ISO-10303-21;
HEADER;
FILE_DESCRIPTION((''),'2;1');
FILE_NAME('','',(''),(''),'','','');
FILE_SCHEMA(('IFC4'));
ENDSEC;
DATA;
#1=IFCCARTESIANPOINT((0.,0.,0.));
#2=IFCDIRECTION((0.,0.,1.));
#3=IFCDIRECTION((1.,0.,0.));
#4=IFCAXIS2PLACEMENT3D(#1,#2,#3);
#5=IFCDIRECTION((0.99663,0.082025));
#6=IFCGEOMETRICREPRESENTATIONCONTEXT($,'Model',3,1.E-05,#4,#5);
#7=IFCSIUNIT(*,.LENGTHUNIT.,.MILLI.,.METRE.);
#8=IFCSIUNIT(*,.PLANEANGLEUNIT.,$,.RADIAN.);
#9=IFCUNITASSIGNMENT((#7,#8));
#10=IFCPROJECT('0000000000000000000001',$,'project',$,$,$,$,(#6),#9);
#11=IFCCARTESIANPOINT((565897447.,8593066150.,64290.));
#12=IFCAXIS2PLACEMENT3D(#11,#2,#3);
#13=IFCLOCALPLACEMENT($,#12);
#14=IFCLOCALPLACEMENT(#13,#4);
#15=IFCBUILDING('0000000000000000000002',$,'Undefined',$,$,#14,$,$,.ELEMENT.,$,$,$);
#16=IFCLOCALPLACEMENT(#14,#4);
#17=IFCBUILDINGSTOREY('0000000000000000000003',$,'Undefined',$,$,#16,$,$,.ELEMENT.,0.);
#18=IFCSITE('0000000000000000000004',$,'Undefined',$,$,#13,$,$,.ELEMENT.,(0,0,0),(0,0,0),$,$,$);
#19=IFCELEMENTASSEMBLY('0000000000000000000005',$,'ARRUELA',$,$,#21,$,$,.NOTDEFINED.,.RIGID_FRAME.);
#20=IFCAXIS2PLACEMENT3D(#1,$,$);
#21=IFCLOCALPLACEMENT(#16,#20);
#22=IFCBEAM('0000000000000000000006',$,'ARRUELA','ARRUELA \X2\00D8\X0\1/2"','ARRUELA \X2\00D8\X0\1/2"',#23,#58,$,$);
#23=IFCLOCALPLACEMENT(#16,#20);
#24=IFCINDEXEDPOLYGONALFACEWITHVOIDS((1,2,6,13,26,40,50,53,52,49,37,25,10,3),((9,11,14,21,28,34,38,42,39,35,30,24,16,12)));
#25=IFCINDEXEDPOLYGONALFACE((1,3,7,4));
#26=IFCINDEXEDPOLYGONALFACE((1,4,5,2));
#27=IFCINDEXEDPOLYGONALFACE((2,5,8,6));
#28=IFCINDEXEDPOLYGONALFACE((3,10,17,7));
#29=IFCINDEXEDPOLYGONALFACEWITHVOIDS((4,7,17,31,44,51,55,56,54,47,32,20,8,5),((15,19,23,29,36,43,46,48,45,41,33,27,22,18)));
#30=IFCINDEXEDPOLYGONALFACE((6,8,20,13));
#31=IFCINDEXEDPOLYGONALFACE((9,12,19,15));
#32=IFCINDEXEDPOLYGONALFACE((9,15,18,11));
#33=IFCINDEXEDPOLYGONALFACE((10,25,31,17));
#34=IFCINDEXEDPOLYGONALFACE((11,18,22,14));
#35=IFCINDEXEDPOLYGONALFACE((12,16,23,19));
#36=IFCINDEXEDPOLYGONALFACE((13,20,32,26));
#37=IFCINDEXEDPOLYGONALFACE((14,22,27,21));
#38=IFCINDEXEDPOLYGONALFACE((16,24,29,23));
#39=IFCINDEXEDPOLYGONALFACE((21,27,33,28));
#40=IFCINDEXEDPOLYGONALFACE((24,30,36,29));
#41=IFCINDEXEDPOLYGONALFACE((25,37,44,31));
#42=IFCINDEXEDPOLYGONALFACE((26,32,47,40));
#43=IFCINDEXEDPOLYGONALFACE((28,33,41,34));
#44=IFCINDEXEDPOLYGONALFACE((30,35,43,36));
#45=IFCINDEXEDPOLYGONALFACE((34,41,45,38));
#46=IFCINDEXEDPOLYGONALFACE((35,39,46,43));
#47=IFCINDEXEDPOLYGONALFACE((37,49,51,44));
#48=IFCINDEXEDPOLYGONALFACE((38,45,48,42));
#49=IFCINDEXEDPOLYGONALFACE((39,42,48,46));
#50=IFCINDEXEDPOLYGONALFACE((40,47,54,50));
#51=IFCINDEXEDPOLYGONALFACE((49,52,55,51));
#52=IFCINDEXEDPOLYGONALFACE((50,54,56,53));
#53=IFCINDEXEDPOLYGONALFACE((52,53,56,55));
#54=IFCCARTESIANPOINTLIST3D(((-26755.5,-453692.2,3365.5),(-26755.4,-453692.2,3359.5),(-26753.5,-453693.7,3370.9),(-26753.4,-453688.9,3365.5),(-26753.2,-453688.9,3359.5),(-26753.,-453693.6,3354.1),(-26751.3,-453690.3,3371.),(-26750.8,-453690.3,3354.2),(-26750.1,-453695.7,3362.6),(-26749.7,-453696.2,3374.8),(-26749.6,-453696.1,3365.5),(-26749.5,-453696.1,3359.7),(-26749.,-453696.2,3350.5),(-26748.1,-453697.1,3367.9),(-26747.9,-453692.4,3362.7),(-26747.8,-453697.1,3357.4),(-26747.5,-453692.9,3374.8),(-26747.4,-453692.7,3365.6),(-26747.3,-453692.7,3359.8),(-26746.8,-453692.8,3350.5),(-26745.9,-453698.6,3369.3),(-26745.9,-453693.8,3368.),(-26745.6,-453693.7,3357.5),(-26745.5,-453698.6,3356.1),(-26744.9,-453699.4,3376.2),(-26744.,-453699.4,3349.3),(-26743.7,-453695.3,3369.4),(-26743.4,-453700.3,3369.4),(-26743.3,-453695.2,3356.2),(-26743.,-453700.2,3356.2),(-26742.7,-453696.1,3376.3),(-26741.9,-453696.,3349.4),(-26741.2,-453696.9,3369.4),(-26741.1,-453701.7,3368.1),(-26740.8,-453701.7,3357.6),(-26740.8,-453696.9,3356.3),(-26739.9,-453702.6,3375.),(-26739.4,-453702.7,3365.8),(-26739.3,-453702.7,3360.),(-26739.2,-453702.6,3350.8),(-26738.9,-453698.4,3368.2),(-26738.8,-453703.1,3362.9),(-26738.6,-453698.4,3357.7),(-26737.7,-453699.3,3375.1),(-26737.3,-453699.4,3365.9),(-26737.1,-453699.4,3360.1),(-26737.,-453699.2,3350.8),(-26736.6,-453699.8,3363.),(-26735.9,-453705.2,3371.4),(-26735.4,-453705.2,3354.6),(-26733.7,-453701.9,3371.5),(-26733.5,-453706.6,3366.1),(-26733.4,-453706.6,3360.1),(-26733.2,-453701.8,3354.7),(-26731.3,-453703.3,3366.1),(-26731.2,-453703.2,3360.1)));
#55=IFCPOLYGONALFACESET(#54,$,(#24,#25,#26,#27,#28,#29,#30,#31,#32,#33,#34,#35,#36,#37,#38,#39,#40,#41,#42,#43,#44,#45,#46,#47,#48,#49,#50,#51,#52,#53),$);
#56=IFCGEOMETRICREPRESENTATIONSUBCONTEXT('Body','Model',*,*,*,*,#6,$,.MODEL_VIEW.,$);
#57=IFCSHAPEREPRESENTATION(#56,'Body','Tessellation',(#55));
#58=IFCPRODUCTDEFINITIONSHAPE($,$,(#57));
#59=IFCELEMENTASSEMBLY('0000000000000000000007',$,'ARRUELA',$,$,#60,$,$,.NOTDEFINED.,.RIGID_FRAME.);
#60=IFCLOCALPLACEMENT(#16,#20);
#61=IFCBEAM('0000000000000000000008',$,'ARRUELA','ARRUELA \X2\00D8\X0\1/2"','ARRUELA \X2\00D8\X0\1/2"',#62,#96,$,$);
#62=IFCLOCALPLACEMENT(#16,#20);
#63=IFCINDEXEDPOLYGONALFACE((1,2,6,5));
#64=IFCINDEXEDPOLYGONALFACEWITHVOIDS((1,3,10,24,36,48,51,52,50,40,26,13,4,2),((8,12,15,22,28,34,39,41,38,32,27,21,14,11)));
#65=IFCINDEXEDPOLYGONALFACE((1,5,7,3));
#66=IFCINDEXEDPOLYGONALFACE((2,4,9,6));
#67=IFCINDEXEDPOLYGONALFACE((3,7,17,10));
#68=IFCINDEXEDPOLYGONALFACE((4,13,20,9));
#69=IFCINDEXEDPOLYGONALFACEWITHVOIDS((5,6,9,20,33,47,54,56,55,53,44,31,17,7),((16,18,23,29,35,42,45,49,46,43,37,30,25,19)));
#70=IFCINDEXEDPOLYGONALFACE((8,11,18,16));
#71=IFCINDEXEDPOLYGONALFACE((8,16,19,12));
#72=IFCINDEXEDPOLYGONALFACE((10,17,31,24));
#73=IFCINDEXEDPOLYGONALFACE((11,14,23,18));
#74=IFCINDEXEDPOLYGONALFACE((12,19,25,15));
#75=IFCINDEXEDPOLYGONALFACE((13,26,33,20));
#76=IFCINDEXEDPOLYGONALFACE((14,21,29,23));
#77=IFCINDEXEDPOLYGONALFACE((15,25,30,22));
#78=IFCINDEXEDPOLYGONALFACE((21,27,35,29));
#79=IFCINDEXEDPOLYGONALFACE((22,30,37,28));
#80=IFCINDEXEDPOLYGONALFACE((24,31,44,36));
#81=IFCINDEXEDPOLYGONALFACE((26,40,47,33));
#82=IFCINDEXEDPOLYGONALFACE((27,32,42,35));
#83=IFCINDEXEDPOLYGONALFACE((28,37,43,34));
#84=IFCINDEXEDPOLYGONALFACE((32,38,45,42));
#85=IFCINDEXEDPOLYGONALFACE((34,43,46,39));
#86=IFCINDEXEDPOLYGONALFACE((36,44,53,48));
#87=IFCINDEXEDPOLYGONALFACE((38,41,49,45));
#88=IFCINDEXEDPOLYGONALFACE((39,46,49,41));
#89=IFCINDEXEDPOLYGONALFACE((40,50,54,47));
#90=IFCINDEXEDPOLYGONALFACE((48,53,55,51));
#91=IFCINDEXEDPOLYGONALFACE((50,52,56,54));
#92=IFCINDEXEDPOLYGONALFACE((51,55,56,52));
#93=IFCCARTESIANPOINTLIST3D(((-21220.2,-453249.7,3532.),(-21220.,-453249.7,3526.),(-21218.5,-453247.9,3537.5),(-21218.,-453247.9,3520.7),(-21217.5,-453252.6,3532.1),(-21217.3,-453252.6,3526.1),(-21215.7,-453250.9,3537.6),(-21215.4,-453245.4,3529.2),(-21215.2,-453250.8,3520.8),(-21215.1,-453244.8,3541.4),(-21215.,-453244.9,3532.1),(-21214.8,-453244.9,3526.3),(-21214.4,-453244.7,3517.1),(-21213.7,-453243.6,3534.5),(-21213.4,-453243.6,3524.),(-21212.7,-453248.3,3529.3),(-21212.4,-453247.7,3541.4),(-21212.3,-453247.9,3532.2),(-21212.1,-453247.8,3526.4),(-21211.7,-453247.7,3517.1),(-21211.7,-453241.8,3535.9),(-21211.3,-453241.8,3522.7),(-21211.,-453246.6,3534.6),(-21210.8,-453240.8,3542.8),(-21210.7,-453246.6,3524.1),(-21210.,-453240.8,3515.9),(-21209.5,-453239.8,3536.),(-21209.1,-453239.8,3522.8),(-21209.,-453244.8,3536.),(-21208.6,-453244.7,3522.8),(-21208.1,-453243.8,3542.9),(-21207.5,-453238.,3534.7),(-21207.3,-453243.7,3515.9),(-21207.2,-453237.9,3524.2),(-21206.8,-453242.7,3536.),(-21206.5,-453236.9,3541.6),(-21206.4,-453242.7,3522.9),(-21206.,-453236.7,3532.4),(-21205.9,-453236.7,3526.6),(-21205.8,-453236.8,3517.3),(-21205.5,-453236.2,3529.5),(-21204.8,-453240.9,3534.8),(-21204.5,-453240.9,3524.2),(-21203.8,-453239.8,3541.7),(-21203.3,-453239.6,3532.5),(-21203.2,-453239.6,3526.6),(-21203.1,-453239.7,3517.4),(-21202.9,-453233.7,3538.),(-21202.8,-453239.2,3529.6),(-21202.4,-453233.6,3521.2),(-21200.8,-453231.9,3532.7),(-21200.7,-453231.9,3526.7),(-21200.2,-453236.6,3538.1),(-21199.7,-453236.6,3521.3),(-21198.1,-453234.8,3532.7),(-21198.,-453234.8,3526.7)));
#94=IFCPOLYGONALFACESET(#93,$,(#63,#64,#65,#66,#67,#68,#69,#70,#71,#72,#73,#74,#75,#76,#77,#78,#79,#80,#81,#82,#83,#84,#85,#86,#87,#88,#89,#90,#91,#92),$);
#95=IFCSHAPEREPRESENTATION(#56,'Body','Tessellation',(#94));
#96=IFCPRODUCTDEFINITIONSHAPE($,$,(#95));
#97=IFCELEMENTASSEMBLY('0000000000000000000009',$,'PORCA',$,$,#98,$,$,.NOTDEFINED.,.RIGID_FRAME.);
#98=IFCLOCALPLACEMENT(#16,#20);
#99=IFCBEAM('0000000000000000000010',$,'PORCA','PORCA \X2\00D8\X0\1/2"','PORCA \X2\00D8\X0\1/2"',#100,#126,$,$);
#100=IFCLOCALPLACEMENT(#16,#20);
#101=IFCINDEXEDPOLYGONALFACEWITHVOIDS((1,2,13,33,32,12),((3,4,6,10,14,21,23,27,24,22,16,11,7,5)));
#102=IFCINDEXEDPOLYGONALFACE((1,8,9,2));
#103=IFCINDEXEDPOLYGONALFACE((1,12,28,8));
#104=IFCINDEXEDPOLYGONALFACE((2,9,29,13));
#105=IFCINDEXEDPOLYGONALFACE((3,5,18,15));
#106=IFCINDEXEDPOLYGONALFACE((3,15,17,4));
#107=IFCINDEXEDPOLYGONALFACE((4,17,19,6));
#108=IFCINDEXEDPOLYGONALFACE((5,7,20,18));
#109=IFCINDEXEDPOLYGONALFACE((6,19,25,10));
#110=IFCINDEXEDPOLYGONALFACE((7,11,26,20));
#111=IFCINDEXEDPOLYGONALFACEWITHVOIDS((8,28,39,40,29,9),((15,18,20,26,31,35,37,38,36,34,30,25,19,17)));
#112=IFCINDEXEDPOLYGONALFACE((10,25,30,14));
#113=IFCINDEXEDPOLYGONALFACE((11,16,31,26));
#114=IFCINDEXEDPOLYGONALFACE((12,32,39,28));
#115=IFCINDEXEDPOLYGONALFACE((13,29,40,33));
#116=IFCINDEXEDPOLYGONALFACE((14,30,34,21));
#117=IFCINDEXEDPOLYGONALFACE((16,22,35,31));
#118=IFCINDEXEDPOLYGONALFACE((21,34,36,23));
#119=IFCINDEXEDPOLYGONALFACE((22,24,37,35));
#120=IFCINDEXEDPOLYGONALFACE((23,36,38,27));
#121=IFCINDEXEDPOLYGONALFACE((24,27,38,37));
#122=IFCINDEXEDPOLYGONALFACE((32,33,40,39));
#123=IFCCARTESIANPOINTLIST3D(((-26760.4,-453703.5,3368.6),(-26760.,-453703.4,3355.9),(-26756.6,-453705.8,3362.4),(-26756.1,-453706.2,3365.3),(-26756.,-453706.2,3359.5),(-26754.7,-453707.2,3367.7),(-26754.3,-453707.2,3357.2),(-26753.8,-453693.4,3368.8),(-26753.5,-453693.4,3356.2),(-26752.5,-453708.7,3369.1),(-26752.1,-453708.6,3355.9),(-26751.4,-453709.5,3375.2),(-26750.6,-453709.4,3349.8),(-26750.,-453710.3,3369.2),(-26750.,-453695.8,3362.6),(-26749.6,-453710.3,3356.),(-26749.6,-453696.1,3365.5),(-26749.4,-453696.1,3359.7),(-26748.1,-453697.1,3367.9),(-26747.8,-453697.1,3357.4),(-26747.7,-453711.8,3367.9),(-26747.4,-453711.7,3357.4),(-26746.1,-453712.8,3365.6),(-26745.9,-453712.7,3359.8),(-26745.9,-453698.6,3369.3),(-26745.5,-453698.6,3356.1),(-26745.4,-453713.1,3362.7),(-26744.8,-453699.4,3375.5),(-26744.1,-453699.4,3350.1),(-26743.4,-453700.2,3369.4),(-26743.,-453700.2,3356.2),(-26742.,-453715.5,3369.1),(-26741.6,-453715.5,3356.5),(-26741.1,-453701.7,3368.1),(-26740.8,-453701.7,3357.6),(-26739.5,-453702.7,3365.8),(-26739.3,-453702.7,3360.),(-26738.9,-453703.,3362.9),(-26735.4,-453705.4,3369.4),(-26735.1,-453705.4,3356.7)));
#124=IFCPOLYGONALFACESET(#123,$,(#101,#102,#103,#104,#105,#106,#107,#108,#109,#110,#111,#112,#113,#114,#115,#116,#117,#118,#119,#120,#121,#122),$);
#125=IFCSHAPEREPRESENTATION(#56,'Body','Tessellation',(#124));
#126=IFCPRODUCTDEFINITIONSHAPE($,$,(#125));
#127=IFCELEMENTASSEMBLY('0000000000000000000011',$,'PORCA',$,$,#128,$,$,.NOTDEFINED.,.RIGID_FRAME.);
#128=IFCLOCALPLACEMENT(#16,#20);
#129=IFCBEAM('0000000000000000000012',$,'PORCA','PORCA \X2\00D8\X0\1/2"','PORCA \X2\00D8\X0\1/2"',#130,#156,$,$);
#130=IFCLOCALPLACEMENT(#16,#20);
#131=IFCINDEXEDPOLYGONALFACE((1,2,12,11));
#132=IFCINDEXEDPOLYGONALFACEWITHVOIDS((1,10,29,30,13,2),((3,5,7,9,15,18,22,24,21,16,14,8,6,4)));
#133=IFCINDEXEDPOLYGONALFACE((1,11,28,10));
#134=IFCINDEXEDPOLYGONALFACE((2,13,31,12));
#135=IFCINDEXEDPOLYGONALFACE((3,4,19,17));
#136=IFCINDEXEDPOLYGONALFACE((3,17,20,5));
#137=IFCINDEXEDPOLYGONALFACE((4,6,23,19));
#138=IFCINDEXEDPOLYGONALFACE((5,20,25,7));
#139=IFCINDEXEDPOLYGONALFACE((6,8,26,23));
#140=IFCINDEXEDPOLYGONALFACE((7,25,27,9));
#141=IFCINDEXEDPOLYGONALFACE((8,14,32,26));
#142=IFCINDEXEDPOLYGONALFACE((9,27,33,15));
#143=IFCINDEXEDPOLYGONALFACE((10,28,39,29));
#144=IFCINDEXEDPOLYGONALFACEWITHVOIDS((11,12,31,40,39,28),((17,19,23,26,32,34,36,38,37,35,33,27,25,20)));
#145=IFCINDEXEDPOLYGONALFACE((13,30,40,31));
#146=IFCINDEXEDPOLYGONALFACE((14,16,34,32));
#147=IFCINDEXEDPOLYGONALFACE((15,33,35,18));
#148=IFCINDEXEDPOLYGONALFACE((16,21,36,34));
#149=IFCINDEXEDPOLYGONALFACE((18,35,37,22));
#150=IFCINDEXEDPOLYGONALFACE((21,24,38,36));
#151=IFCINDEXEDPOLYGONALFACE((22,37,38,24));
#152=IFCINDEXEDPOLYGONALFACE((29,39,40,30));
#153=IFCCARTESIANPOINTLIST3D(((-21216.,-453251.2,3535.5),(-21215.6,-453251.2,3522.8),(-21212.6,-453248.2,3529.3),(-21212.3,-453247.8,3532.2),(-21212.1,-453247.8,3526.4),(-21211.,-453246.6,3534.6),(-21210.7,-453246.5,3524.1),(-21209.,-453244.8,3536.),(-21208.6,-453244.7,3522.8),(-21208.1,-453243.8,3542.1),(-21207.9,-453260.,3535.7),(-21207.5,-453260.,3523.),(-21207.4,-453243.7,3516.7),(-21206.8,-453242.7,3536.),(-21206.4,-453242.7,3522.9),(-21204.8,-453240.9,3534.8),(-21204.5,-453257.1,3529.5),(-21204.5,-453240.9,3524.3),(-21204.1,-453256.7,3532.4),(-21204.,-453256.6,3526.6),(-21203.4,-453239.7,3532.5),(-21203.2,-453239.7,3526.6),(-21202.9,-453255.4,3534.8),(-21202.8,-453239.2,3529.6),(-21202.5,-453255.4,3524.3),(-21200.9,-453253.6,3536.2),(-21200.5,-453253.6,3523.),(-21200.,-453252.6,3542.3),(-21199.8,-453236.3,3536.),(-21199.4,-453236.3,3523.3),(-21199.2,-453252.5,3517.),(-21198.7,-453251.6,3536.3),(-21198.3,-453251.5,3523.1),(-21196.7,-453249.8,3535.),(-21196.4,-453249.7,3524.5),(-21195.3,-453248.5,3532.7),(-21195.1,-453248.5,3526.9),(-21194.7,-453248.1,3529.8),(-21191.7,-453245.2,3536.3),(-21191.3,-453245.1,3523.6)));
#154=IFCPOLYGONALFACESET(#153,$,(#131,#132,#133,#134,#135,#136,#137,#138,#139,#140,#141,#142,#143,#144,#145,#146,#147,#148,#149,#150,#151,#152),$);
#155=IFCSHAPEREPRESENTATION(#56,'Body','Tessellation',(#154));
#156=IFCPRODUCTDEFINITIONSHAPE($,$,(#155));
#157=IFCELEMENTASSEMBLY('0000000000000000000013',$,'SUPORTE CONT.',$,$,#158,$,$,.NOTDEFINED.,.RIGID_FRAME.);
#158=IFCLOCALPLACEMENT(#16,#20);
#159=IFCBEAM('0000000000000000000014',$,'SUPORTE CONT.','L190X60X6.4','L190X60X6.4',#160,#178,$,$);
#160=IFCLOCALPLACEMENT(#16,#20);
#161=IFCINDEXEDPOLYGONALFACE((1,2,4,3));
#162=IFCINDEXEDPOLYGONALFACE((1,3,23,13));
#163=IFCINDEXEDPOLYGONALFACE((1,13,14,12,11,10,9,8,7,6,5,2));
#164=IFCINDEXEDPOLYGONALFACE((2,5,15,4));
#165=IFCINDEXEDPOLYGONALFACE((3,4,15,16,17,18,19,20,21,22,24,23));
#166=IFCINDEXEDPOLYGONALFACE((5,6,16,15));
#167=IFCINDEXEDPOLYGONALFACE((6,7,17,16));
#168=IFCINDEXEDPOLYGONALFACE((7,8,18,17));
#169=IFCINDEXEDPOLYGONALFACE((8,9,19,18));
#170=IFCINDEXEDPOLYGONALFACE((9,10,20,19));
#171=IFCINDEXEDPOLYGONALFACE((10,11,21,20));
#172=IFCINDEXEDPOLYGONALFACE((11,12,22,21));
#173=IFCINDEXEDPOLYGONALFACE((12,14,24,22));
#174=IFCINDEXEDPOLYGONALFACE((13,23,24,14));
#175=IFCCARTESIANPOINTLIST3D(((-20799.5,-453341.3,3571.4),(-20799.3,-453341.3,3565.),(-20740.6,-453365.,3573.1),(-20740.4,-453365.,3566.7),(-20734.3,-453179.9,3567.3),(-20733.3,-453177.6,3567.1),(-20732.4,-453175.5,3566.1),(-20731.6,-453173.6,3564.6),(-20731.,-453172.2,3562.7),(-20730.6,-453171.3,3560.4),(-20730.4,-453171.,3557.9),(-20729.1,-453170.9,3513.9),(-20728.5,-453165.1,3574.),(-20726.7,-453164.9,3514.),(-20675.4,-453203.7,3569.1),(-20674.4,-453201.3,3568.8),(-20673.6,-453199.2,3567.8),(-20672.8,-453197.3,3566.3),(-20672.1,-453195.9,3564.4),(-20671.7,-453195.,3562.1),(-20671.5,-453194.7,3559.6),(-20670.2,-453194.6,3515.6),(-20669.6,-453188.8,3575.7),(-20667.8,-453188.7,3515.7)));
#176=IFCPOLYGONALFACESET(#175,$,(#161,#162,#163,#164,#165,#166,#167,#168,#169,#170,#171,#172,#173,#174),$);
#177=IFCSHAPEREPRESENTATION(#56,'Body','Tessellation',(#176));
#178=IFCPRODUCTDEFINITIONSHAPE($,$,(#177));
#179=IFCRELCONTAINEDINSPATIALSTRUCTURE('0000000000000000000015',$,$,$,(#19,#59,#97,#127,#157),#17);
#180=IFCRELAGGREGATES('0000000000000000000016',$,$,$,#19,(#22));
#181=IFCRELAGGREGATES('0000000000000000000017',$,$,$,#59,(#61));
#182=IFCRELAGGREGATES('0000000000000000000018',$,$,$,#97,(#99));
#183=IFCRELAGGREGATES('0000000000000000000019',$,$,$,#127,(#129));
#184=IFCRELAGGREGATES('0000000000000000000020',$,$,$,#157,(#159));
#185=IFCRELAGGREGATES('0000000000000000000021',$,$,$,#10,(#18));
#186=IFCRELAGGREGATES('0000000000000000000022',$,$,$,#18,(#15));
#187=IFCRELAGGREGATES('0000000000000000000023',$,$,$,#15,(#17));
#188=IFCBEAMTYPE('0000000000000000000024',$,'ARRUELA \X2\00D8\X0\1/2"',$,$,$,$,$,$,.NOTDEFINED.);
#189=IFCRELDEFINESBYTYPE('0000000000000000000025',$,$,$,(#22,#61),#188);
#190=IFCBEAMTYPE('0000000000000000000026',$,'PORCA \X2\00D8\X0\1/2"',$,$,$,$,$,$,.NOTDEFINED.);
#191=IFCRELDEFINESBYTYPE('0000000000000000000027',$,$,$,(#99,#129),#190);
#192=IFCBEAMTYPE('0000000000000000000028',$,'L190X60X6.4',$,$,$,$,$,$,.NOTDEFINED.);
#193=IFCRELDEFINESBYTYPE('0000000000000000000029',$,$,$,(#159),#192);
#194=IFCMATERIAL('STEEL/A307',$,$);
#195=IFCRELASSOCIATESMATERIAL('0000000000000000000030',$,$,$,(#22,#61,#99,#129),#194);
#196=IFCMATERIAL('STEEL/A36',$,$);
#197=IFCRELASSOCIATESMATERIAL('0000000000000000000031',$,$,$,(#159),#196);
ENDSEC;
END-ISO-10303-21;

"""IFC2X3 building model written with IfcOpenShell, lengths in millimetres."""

from ifc_helpers import new_model, si_unit, direction, frame, origin_with_axes, origin_2d_with_axis, place, context, subcontext, project, spatial, polyline, l_section, outline, extrude, material, type_object, element, aggregate, save


model = new_model("IFC2X3")

# Units and contexts
model_context = context("Model", 3, precision=1e-05, world=origin_with_axes(), true_north=direction((0.99663, 0.082025)))
body_context = subcontext(model_context, "Body", "Model", "MODEL_VIEW")
ifc_project = project(units=[si_unit("LENGTHUNIT", "METRE", prefix="MILLI"), si_unit("PLANEANGLEUNIT", "RADIAN")], contexts=[model_context])

# Site, building, storey
site_placement = place(None, frame((565897447.0, 8593066150.0, 64290.0), z_axis=(0.0, 0.0, 1.0), x_axis=(1.0, 0.0, 0.0)))
site = spatial("IfcSite", under=ifc_project, at=site_placement, Name="Undefined", CompositionType="ELEMENT", RefLatitude=(0, 0, 0), RefLongitude=(0, 0, 0))
building_placement = place(site_placement, origin_with_axes())
building = spatial("IfcBuilding", under=site, at=building_placement, Name="Undefined", CompositionType="ELEMENT")
storey_placement = place(building_placement, origin_with_axes())
storey = spatial("IfcBuildingStorey", under=building, at=storey_placement, Name="Undefined", CompositionType="ELEMENT", Elevation=0.0)

# Element assemblies, beams
assembly_1_placement = place(storey_placement, origin_with_axes())
assembly_1 = element("IfcElementAssembly", 1, at=assembly_1_placement, inside=storey, Name="ARRUELA", AssemblyPlace="NOTDEFINED", PredefinedType="RIGID_FRAME")
ifc_material_1 = material(Name="STEEL/A307")
beam_type_1 = type_object("IfcBeamType", Name="ARRUELA Ø1/2\"", PredefinedType="NOTDEFINED")
beam_1_placement = place(assembly_1_placement, frame((-26744.4, -453699.4, 3362.8), z_axis=(0.836984, -0.546715, 0.02368), x_axis=(0.546411, 0.837315, 0.018398)))
beam_1 = element("IfcBeam", 2, at=beam_1_placement, type_object=beam_type_1, material=ifc_material_1, Name="ARRUELA", Description="ARRUELA Ø1/2\"", ObjectType="ARRUELA Ø1/2\"", context=body_context, shape_type="SweptSolid", body=[
    extrude(outline(polyline([(-12.2, 5.9), (-8.4, 10.5), (-3.0, 13.2), (3.0, 13.2), (8.4, 10.5), (12.2, 5.9), (13.5, 0.0), (12.2, -5.9), (8.4, -10.5), (3.0, -13.2), (-3.0, -13.2), (-8.4, -10.5), (-12.2, -5.9), (-13.5, 0.0), (-12.2, 5.9)]), holes=[polyline([(5.3, 4.2), (2.9, 6.1), (0.0, 6.8), (-2.9, 6.1), (-5.3, 4.2), (-6.6, 1.5), (-6.6, -1.5), (-5.3, -4.2), (-2.9, -6.1), (0.0, -6.7), (2.9, -6.1), (5.3, -4.2), (6.6, -1.5), (6.6, 1.5), (5.3, 4.2)])]), frame((4.0, 0.0, 0.0), z_axis=(-1.0, 0.0, 0.0), x_axis=(0.0, -1.0, 0.0)), (0.0, 0.0, 1.0), 4.0),
])
aggregate(assembly_1, [beam_1])
assembly_2_placement = place(storey_placement, origin_with_axes())
assembly_2 = element("IfcElementAssembly", 3, at=assembly_2_placement, inside=storey, Name="ARRUELA", AssemblyPlace="NOTDEFINED", PredefinedType="RIGID_FRAME")
beam_2_placement = place(assembly_2_placement, frame((-21207.7, -453243.7, 3529.4), z_axis=(0.736334, 0.676203, 0.02368), x_axis=(-0.675958, 0.736711, -0.018398)))
beam_2 = element("IfcBeam", 4, at=beam_2_placement, type_object=beam_type_1, material=ifc_material_1, Name="ARRUELA", Description="ARRUELA Ø1/2\"", ObjectType="ARRUELA Ø1/2\"", context=body_context, shape_type="SweptSolid", body=[
    extrude(outline(polyline([(-12.2, 5.9), (-8.4, 10.5), (-3.0, 13.2), (3.0, 13.2), (8.4, 10.5), (12.2, 5.9), (13.5, 0.0), (12.2, -5.9), (8.4, -10.5), (3.0, -13.2), (-3.0, -13.2), (-8.4, -10.5), (-12.2, -5.9), (-13.5, 0.0), (-12.2, 5.9)]), holes=[polyline([(5.3, 4.2), (2.9, 6.1), (0.0, 6.8), (-2.9, 6.1), (-5.3, 4.2), (-6.6, 1.5), (-6.6, -1.5), (-5.3, -4.2), (-2.9, -6.1), (0.0, -6.7), (2.9, -6.1), (5.3, -4.2), (6.6, -1.5), (6.6, 1.5), (5.3, 4.2)])]), frame((4.0, 0.0, 0.0), z_axis=(-1.0, 0.0, 0.0), x_axis=(0.0, -1.0, 0.0)), (0.0, 0.0, 1.0), 4.0),
])
aggregate(assembly_2, [beam_2])
assembly_3_placement = place(storey_placement, origin_with_axes())
assembly_3 = element("IfcElementAssembly", 5, at=assembly_3_placement, inside=storey, Name="PORCA", AssemblyPlace="NOTDEFINED", PredefinedType="RIGID_FRAME")
beam_type_2 = type_object("IfcBeamType", Name="PORCA Ø1/2\"", PredefinedType="NOTDEFINED")
beam_3_placement = place(assembly_3_placement, frame((-26751.0, -453709.5, 3362.5), z_axis=(0.836984, -0.546715, 0.02368), x_axis=(0.546411, 0.837315, 0.018398)))
beam_3 = element("IfcBeam", 6, at=beam_3_placement, type_object=beam_type_2, material=ifc_material_1, Name="PORCA", Description="PORCA Ø1/2\"", ObjectType="PORCA Ø1/2\"", context=body_context, shape_type="SweptSolid", body=[
    extrude(outline(polyline([(-6.3, -11.0), (-12.7, 0.0), (-6.3, 11.0), (6.3, 11.0), (12.7, 0.0), (6.3, -11.0), (-6.3, -11.0)]), holes=[polyline([(5.3, 4.2), (2.9, 6.0), (0.0, 6.7), (-2.9, 6.0), (-5.3, 4.2), (-6.6, 1.5), (-6.6, -1.5), (-5.3, -4.2), (-2.9, -6.0), (0.0, -6.7), (2.9, -6.0), (5.3, -4.2), (6.6, -1.5), (6.6, 1.5), (5.3, 4.2)])]), frame((12.0, 0.0, 0.0), z_axis=(-1.0, 0.0, 0.0), x_axis=(0.0, -1.0, 0.0)), (0.0, 0.0, 1.0), 12.0),
])
aggregate(assembly_3, [beam_3])
assembly_4_placement = place(storey_placement, origin_with_axes())
assembly_4 = element("IfcElementAssembly", 7, at=assembly_4_placement, inside=storey, Name="PORCA", AssemblyPlace="NOTDEFINED", PredefinedType="RIGID_FRAME")
beam_4_placement = place(assembly_4_placement, frame((-21199.6, -453252.6, 3529.6), z_axis=(0.736334, 0.676203, 0.02368), x_axis=(-0.675958, 0.736711, -0.018398)))
beam_4 = element("IfcBeam", 8, at=beam_4_placement, type_object=beam_type_2, material=ifc_material_1, Name="PORCA", Description="PORCA Ø1/2\"", ObjectType="PORCA Ø1/2\"", context=body_context, shape_type="SweptSolid", body=[
    extrude(outline(polyline([(-6.3, -11.0), (-12.7, 0.0), (-6.3, 11.0), (6.3, 11.0), (12.7, 0.0), (6.3, -11.0), (-6.3, -11.0)]), holes=[polyline([(5.3, 4.2), (2.9, 6.0), (0.0, 6.7), (-2.9, 6.0), (-5.3, 4.2), (-6.6, 1.5), (-6.6, -1.5), (-5.3, -4.2), (-2.9, -6.0), (0.0, -6.7), (2.9, -6.0), (5.3, -4.2), (6.6, -1.5), (6.6, 1.5), (5.3, 4.2)])]), frame((12.0, 0.0, 0.0), z_axis=(-1.0, 0.0, 0.0), x_axis=(0.0, -1.0, 0.0)), (0.0, 0.0, 1.0), 12.0),
])
aggregate(assembly_4, [beam_4])
assembly_5_placement = place(storey_placement, origin_with_axes())
assembly_5 = element("IfcElementAssembly", 9, at=assembly_5_placement, inside=storey, Name="SUPORTE CONT.", AssemblyPlace="NOTDEFINED", PredefinedType="RIGID_FRAME")
ifc_material_2 = material(Name="STEEL/A36")
beam_type_3 = type_object("IfcBeamType", Name="L190X60X6.4", PredefinedType="NOTDEFINED")
beam_5_placement = place(assembly_5_placement, frame((-20763.1, -453253.1, 3542.7), z_axis=(-0.373645, -0.927474, -0.013454), x_axis=(0.92709, -0.373879, 0.026799)))
beam_5 = element("IfcBeam", 10, at=beam_5_placement, type_object=beam_type_3, material=ifc_material_2, Name="SUPORTE CONT.", Description="L190X60X6.4", ObjectType="L190X60X6.4", context=body_context, shape_type="SweptSolid", body=[
    extrude(l_section(Depth=190.0, Width=60.0, Thickness=6.4, FilletRadius=9.6, at=origin_2d_with_axis()), frame((63.5, 0.0, 0.0), z_axis=(-1.0, 0.0, 0.0), x_axis=(0.0, -1.0, 0.0)), (0.0, 0.0, 1.0), 63.5),
])
aggregate(assembly_5, [beam_5])

save(model, "model.ifc")
